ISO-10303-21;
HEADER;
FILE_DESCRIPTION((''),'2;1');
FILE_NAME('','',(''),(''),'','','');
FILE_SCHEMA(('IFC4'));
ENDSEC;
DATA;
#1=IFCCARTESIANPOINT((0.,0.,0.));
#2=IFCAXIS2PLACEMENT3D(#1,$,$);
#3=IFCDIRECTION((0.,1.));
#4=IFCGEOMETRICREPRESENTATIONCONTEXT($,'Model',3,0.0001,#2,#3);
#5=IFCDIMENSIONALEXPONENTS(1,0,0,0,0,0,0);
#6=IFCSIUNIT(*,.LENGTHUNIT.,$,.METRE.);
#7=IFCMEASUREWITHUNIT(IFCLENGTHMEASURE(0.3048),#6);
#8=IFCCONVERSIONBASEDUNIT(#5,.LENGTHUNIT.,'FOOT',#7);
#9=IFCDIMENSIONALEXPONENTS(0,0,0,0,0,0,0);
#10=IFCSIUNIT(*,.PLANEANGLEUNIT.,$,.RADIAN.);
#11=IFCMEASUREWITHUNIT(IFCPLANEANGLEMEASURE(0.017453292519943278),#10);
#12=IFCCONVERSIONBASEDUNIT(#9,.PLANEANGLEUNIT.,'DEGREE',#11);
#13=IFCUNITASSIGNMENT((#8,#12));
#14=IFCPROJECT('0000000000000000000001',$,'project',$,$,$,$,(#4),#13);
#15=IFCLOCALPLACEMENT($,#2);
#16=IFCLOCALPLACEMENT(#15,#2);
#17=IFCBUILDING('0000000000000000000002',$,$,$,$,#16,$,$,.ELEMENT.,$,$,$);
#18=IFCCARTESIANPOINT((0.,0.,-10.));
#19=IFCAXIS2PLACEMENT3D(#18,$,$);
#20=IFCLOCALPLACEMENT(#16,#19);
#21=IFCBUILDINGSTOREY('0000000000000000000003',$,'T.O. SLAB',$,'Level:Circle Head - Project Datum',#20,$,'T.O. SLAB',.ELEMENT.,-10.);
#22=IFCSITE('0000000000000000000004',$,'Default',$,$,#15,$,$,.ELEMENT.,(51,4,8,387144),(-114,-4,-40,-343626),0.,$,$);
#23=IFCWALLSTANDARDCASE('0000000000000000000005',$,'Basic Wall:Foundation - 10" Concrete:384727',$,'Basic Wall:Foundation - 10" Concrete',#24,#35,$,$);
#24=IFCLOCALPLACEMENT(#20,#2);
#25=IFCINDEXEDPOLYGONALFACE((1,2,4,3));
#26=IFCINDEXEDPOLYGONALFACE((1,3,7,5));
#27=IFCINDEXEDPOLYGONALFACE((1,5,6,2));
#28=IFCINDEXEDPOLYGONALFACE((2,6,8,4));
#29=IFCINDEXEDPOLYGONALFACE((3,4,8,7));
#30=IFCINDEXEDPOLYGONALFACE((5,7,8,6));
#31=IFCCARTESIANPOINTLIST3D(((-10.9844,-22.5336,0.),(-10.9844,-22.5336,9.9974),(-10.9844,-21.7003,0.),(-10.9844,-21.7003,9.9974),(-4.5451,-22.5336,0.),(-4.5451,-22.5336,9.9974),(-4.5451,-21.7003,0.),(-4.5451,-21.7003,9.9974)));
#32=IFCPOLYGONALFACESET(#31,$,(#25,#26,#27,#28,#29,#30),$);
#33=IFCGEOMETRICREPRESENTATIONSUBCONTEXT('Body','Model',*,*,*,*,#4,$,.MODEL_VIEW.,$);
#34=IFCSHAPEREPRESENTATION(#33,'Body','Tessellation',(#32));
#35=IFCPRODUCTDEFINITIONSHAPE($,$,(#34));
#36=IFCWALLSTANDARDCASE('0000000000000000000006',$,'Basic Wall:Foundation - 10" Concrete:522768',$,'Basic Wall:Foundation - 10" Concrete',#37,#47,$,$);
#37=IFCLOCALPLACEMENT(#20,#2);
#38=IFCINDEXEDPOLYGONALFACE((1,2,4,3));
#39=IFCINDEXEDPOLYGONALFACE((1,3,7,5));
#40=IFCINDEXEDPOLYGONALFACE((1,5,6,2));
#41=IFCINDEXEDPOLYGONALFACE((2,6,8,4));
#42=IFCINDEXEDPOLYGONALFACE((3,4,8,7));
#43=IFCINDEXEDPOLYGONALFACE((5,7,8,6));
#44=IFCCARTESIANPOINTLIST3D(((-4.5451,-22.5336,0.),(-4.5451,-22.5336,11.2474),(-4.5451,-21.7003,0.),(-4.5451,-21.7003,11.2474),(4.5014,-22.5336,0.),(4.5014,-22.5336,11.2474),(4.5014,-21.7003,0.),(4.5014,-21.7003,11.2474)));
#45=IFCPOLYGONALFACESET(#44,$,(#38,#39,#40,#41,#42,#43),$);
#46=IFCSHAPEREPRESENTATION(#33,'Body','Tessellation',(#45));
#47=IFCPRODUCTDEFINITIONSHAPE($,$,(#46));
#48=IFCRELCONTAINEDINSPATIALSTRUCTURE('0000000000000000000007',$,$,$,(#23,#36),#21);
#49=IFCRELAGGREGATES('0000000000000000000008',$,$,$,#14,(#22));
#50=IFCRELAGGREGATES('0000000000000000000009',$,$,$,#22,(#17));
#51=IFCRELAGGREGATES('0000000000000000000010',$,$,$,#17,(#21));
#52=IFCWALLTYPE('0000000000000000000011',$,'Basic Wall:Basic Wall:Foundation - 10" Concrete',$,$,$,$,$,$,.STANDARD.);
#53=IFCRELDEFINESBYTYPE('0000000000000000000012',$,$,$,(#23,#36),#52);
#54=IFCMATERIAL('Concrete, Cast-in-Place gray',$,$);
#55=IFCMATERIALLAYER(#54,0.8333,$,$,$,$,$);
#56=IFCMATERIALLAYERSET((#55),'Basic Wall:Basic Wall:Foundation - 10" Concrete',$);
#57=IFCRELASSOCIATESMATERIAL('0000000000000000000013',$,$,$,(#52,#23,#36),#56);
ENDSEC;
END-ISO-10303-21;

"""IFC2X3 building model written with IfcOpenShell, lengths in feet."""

from ifc_helpers import new_model, entity, si_unit, converted_unit, direction, frame, frame_2d, origin, place, context, subcontext, project, spatial, rectangle, extrude, material, layer, layer_set, layer_usage, type_object, element, save


model = new_model("IFC2X3")

# Units and contexts
model_context = context("Model", 3, precision=0.0001, world=origin(), true_north=direction((0.0, 1.0)))
body_context = subcontext(model_context, "Body", "Model", "MODEL_VIEW")
ifc_project = project(units=[converted_unit("LENGTHUNIT", "FOOT", entity("IfcLengthMeasure", 0.3048), si_unit("LENGTHUNIT", "METRE"), dimensions=[1, 0, 0, 0, 0, 0, 0]), converted_unit("PLANEANGLEUNIT", "DEGREE", entity("IfcPlaneAngleMeasure", 0.017453292519943278), si_unit("PLANEANGLEUNIT", "RADIAN"), dimensions=[0, 0, 0, 0, 0, 0, 0])], contexts=[model_context])

# Site, building, storey
site_placement = place(None, origin())
site = spatial("IfcSite", under=ifc_project, at=site_placement, Name="Default", CompositionType="ELEMENT", RefLatitude=(51, 4, 8, 387144), RefLongitude=(-114, -4, -40, -343626), RefElevation=0.0)
building_placement = place(site_placement, origin())
building = spatial("IfcBuilding", under=site, at=building_placement, CompositionType="ELEMENT")
storey_placement = place(building_placement, frame((0.0, 0.0, -10.0)))
storey = spatial("IfcBuildingStorey", under=building, at=storey_placement, Name="T.O. SLAB", ObjectType="Level:Circle Head - Project Datum", LongName="T.O. SLAB", CompositionType="ELEMENT", Elevation=-10.0)

# Shared definitions
ifc_material_1 = material(Name="Concrete, Cast-in-Place gray")
ifc_layer_1 = layer(ifc_material_1, 0.8333)
ifc_layer_set_1 = layer_set([ifc_layer_1], Name="Basic Wall:Basic Wall:Foundation - 10\" Concrete")
wall_type_1 = type_object("IfcWallType", Name="Basic Wall:Basic Wall:Foundation - 10\" Concrete", PredefinedType="STANDARD", material=ifc_layer_set_1)

# Walls
ifc_layer_usage_1 = layer_usage(ifc_layer_set_1, "AXIS2", "NEGATIVE", 0.4167)
wall_1_placement = place(storey_placement, frame((-10.9844, -22.117, 0.0)))
element("IfcWallStandardCase", 1, at=wall_1_placement, inside=storey, type_object=wall_type_1, material=ifc_layer_usage_1, Name="Basic Wall:Foundation - 10\" Concrete:384727", ObjectType="Basic Wall:Foundation - 10\" Concrete", context=body_context, shape_type="SweptSolid", body=[
    extrude(rectangle(XDim=6.4392, YDim=0.8333, at=frame_2d((3.2196, 0.0), x_axis=(-1.0, 0.0))), origin(), (0.0, 0.0, 1.0), 9.9974),
])
ifc_layer_usage_2 = layer_usage(ifc_layer_set_1, "AXIS2", "NEGATIVE", 0.4167)
wall_2_placement = place(storey_placement, frame((-4.5451, -22.117, 0.0)))
element("IfcWallStandardCase", 2, at=wall_2_placement, inside=storey, type_object=wall_type_1, material=ifc_layer_usage_2, Name="Basic Wall:Foundation - 10\" Concrete:522768", ObjectType="Basic Wall:Foundation - 10\" Concrete", context=body_context, shape_type="SweptSolid", body=[
    extrude(rectangle(XDim=9.0466, YDim=0.8333, at=frame_2d((4.5233, 0.0), x_axis=(-1.0, 0.0))), origin(), (0.0, 0.0, 1.0), 11.2474),
])

save(model, "model.ifc")
